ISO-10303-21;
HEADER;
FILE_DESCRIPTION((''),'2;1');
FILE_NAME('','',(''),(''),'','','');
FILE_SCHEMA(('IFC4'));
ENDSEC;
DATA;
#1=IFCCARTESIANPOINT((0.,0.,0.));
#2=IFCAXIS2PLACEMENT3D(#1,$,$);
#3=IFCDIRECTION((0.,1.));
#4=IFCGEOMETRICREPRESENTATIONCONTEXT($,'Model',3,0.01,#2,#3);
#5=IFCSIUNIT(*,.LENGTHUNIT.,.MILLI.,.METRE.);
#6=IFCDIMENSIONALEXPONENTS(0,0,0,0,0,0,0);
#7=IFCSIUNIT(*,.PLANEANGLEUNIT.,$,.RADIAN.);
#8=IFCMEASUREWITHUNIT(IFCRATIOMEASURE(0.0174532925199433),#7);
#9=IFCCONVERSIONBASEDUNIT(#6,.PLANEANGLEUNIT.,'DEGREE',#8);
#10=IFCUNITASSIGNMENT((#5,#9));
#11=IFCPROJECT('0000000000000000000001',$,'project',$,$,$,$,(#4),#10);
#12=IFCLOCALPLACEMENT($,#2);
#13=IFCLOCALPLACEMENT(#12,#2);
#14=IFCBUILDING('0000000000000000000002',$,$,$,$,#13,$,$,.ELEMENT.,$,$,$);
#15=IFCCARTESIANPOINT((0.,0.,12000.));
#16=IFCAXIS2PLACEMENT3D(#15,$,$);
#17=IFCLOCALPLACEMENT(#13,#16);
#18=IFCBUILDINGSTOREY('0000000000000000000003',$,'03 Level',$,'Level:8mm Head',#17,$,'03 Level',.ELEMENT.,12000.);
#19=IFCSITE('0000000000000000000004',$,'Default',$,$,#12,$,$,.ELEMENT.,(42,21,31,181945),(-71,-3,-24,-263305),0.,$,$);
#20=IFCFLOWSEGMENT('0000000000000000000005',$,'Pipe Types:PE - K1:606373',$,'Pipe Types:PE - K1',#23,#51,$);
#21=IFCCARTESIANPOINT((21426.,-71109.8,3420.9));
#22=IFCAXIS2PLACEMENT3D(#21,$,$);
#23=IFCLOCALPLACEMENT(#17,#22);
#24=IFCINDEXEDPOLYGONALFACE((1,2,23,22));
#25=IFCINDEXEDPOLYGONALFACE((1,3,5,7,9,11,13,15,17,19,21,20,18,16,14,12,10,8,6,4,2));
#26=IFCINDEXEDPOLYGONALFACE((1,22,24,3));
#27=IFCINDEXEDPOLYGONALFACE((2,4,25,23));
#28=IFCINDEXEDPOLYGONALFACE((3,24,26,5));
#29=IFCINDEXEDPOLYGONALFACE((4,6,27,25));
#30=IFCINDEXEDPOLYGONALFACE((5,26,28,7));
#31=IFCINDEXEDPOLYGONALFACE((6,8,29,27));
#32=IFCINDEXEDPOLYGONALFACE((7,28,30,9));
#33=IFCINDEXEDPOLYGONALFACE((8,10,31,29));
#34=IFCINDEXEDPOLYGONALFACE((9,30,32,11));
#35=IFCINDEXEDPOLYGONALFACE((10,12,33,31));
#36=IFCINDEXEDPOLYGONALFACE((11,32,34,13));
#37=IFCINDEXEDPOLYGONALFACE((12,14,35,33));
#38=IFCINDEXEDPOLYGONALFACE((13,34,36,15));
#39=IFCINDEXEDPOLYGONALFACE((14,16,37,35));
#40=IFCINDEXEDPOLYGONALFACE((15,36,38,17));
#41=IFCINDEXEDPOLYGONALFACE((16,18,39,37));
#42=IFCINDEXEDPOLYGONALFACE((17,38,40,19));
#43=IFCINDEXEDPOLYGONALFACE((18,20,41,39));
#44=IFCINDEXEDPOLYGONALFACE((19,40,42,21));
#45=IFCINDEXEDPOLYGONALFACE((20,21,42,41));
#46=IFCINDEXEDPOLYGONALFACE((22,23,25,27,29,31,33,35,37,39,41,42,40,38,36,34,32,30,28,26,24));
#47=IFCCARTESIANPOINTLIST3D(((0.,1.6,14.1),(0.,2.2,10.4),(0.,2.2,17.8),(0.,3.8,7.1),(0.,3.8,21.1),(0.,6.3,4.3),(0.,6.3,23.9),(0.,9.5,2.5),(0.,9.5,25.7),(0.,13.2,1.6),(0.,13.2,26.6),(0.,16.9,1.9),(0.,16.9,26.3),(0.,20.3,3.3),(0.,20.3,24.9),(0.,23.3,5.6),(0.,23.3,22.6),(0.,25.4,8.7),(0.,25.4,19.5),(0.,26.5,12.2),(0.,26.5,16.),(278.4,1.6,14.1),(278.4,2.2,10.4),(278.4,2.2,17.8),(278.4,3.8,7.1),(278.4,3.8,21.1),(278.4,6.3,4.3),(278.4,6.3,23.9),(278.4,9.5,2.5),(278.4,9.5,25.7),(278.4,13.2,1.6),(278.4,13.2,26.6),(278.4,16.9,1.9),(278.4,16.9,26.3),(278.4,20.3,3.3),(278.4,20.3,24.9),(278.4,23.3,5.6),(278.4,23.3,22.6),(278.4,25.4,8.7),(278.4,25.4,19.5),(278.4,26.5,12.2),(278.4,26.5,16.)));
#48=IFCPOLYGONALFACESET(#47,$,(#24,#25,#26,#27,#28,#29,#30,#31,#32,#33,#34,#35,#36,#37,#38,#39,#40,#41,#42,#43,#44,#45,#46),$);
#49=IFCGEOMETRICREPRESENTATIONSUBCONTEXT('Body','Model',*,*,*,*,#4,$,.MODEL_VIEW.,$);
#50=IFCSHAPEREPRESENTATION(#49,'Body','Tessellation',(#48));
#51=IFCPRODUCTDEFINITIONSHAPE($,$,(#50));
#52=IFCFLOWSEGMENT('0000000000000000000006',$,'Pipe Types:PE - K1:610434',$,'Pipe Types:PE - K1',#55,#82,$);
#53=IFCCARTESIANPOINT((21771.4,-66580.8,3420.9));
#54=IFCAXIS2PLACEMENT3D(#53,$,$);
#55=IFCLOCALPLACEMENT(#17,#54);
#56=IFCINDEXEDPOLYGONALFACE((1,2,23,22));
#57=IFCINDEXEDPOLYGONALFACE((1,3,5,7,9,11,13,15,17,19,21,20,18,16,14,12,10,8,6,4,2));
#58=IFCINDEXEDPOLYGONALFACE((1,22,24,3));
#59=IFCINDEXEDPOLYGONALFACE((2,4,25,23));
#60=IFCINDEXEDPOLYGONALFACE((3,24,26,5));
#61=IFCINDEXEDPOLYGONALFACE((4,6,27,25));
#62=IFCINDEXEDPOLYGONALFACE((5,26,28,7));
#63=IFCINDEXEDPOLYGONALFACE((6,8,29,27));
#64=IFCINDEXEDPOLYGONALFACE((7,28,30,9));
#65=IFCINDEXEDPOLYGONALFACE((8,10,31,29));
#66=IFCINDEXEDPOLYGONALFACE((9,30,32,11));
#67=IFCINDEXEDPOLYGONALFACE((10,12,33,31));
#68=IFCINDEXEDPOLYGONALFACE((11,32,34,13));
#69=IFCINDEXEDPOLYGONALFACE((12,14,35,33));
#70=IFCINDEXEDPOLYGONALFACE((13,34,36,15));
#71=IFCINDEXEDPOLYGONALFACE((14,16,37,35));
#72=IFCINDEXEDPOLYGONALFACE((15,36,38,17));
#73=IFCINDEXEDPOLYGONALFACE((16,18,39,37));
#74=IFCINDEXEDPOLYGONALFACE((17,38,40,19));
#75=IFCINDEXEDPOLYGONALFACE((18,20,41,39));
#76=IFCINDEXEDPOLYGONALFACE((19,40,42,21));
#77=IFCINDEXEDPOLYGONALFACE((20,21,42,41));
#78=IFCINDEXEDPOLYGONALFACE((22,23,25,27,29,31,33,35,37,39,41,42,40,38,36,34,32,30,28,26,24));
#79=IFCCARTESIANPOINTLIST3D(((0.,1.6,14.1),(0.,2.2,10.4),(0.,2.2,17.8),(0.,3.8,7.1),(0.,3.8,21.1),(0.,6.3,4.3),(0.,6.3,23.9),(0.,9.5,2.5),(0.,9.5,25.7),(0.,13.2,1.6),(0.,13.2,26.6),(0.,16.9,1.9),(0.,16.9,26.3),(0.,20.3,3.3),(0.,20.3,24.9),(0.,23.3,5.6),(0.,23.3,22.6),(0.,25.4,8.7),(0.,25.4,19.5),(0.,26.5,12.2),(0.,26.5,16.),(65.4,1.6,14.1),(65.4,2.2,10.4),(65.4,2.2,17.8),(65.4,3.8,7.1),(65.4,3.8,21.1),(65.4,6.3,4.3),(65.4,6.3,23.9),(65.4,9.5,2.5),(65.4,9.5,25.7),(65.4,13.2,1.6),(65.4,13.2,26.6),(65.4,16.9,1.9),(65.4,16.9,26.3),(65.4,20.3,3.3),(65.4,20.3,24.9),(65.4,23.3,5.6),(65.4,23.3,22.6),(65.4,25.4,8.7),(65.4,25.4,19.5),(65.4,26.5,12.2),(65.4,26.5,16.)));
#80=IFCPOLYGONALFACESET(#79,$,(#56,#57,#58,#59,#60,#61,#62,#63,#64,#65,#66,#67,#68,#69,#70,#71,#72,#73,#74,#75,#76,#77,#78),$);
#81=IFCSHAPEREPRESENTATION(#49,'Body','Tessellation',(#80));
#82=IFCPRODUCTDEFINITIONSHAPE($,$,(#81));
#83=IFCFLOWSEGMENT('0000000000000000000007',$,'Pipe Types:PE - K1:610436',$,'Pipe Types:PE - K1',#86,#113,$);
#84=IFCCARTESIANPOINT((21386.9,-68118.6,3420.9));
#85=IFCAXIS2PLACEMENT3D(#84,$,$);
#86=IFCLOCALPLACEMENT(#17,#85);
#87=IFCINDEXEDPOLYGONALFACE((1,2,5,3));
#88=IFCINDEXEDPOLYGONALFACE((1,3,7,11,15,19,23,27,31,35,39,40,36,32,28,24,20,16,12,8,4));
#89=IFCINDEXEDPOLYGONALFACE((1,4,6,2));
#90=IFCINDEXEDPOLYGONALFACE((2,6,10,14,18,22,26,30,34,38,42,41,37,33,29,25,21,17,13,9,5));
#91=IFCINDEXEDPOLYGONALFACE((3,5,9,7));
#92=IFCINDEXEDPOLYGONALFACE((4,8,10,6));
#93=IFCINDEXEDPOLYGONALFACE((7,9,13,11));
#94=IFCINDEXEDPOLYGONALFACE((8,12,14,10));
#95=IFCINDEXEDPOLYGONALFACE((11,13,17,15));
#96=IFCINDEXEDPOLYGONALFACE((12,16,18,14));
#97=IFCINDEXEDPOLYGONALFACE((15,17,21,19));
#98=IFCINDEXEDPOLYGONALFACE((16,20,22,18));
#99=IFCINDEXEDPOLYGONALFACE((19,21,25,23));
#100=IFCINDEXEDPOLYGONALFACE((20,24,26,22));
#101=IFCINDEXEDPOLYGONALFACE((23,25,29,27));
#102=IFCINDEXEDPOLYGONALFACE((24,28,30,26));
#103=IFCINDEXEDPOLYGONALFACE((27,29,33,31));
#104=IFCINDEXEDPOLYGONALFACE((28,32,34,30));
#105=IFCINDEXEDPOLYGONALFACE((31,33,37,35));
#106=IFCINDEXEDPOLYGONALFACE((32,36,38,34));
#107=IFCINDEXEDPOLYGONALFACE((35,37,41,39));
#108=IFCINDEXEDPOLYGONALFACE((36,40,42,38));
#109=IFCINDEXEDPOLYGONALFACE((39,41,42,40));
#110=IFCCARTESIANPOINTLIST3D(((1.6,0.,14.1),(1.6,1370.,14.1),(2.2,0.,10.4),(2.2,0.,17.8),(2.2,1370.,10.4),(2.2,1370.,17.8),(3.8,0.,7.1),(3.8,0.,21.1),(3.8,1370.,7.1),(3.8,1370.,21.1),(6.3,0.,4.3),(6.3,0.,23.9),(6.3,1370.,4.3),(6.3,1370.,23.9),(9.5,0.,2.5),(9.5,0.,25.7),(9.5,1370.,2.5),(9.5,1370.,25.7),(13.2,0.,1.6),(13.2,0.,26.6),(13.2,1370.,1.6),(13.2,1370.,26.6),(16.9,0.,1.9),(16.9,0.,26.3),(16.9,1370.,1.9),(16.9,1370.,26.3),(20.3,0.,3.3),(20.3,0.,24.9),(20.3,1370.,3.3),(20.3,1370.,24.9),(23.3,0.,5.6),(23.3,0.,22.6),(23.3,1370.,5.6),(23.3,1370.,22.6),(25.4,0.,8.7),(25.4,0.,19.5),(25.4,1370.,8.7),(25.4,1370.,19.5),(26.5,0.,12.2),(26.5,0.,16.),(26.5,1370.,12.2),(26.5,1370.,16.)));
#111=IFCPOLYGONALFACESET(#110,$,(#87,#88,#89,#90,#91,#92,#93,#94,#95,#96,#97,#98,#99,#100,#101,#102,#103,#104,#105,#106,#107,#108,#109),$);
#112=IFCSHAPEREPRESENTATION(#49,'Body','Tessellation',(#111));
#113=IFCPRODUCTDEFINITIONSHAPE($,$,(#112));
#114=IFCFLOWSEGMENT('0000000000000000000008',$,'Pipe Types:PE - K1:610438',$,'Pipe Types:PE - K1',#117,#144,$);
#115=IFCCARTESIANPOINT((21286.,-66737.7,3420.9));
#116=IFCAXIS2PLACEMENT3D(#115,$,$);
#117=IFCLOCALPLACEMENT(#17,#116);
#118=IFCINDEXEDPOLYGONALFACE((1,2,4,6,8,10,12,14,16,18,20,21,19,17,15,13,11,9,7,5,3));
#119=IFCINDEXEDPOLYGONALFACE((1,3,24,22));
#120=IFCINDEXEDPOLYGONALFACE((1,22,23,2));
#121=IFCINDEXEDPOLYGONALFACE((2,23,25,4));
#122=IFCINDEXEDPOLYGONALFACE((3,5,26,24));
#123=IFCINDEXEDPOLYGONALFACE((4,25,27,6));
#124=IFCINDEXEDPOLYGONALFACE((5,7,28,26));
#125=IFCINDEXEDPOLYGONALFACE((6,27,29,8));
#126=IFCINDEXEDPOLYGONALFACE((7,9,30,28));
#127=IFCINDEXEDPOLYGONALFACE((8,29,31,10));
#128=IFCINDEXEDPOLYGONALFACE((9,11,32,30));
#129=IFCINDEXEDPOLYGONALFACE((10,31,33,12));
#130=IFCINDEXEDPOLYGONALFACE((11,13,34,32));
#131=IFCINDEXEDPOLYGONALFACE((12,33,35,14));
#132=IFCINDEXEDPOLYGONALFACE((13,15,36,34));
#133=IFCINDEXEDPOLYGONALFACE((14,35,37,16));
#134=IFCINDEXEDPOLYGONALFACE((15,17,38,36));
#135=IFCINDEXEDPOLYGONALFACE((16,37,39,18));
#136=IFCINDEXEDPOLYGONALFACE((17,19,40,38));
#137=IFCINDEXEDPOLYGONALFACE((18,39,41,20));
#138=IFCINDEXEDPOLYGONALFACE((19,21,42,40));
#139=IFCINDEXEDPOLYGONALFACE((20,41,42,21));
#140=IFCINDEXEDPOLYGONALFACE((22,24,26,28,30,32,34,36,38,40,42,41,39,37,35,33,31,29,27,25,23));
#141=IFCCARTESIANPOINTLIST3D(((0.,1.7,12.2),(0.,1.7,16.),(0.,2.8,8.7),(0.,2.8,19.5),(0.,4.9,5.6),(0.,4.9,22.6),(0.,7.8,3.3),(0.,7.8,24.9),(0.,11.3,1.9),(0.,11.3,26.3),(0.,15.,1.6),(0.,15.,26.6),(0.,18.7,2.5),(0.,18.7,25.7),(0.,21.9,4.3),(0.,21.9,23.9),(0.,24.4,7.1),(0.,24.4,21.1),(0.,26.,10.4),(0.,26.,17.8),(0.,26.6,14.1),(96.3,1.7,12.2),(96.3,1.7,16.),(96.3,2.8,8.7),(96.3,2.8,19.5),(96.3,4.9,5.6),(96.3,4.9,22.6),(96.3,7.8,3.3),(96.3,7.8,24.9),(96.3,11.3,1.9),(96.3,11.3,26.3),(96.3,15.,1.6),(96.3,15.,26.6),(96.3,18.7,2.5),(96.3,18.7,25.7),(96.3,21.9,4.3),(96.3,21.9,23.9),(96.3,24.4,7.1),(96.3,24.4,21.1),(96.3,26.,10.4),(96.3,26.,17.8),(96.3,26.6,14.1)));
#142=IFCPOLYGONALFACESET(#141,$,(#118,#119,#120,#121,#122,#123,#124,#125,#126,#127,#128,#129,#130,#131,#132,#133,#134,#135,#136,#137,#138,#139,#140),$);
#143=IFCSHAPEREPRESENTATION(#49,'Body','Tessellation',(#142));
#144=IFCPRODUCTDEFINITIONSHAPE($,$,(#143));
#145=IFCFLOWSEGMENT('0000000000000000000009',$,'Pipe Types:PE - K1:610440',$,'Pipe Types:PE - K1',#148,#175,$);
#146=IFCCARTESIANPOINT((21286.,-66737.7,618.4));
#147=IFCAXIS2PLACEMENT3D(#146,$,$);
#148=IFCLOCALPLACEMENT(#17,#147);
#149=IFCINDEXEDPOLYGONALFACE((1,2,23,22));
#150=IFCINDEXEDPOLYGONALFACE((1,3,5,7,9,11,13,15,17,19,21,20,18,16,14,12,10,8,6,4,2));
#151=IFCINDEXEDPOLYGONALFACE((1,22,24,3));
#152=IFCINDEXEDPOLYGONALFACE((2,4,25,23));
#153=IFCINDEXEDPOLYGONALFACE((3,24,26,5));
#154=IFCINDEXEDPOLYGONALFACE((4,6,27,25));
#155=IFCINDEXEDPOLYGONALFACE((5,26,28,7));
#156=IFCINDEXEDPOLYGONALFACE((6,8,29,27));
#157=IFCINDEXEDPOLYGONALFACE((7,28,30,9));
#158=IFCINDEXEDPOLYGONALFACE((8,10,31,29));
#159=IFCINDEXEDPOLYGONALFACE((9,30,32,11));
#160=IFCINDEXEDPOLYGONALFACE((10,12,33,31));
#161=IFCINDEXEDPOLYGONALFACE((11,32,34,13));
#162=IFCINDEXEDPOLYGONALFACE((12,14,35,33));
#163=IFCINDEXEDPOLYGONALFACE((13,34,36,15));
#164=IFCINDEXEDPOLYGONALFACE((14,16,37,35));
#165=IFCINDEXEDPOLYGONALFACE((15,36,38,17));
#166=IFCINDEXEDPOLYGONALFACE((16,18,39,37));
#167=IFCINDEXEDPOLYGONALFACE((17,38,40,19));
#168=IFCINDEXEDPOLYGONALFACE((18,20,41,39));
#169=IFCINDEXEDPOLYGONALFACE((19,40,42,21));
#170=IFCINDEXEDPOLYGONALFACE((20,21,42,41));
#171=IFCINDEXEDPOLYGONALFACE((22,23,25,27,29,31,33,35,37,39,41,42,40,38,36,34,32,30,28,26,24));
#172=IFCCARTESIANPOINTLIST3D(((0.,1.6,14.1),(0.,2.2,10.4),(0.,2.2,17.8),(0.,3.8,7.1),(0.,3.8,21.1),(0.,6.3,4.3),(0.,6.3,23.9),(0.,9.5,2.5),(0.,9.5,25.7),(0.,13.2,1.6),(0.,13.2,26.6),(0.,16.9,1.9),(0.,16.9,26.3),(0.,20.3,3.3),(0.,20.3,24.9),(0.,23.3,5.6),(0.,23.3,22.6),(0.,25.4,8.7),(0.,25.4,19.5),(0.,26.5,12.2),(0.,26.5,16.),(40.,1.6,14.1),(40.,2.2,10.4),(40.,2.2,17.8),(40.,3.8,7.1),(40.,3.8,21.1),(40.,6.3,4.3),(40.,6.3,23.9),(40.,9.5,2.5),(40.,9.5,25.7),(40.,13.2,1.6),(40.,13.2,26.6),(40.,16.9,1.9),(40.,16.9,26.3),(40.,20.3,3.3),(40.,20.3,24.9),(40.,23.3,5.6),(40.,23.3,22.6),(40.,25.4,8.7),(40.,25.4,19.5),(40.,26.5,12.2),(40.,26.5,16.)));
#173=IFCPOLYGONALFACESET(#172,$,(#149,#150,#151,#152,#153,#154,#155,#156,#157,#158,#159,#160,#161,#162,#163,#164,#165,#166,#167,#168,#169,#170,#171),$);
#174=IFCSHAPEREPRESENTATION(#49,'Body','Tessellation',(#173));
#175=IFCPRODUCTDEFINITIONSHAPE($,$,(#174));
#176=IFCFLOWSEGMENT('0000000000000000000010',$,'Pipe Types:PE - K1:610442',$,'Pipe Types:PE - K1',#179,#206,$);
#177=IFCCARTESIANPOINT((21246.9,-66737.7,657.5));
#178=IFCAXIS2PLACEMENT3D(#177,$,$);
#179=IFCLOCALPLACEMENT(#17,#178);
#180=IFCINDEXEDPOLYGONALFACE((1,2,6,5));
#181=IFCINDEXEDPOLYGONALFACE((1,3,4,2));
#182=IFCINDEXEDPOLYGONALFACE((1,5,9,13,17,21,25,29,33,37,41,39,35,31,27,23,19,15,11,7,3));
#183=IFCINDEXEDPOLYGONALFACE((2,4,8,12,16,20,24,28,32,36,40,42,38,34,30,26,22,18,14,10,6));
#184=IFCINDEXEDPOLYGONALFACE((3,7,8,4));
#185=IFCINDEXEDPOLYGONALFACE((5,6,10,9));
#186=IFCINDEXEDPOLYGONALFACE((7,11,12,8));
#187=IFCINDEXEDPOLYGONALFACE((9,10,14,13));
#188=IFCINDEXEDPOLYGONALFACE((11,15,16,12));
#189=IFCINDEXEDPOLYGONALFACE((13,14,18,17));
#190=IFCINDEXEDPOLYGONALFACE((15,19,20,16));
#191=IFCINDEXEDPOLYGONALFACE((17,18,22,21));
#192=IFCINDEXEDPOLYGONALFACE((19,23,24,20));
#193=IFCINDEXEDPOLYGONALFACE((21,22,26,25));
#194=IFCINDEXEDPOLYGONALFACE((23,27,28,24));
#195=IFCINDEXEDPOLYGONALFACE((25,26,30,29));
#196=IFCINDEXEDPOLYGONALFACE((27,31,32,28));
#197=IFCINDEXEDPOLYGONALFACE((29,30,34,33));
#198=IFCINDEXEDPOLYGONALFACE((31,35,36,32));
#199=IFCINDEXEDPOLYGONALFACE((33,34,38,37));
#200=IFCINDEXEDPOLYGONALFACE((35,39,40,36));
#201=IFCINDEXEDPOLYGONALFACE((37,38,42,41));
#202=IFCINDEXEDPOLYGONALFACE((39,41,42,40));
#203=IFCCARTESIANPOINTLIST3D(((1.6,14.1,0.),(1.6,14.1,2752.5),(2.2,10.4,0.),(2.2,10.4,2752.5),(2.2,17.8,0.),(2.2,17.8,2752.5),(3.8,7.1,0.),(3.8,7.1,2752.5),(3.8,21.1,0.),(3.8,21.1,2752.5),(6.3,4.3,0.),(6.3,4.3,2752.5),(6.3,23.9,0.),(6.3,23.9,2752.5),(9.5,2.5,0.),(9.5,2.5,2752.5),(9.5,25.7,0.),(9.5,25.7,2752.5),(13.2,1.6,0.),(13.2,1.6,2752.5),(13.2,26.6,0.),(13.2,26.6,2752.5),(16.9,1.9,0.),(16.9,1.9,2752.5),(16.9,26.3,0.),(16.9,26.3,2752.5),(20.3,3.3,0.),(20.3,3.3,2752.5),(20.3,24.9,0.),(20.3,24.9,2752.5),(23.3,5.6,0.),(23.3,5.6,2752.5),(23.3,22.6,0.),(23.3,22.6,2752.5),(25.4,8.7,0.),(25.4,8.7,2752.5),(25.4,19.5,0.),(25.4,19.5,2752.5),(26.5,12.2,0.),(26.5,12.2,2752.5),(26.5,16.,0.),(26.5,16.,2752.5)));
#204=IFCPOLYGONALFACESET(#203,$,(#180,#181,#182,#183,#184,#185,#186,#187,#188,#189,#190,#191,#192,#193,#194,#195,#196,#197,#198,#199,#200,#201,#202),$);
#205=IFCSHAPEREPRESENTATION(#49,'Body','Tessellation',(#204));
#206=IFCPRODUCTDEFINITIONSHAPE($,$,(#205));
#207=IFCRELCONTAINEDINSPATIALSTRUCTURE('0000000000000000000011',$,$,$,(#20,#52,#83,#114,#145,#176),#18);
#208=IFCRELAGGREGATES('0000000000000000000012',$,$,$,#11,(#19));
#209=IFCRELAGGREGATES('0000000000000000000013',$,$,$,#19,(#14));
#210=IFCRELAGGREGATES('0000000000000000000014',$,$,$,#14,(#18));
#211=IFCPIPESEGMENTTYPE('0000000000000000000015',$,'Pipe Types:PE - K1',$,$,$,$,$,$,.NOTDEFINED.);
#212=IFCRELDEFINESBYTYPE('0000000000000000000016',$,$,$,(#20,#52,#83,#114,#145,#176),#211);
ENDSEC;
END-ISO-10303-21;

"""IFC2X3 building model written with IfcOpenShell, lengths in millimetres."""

from ifc_helpers import new_model, entity, si_unit, converted_unit, direction, frame, frame_2d, origin, origin_2d_with_axis, place, context, subcontext, project, spatial, circle, extrude, type_object, element, save


model = new_model("IFC2X3")

# Units and contexts
model_context = context("Model", 3, precision=0.01, world=origin(), true_north=direction((0.0, 1.0)))
body_context = subcontext(model_context, "Body", "Model", "MODEL_VIEW")
ifc_project = project(units=[si_unit("LENGTHUNIT", "METRE", prefix="MILLI"), converted_unit("PLANEANGLEUNIT", "DEGREE", entity("IfcRatioMeasure", 0.0174532925199433), si_unit("PLANEANGLEUNIT", "RADIAN"), dimensions=[0, 0, 0, 0, 0, 0, 0])], contexts=[model_context])

# Site, building, storey
site_placement = place(None, origin())
site = spatial("IfcSite", under=ifc_project, at=site_placement, Name="Default", CompositionType="ELEMENT", RefLatitude=(42, 21, 31, 181945), RefLongitude=(-71, -3, -24, -263305), RefElevation=0.0)
building_placement = place(site_placement, origin())
building = spatial("IfcBuilding", under=site, at=building_placement, CompositionType="ELEMENT")
storey_placement = place(building_placement, frame((0.0, 0.0, 12000.0)))
storey = spatial("IfcBuildingStorey", under=building, at=storey_placement, Name="03 Level", ObjectType="Level:8mm Head", LongName="03 Level", CompositionType="ELEMENT", Elevation=12000.0)

# Flow segments
pipe_segment_type = type_object("IfcPipeSegmentType", Name="Pipe Types:PE - K1", PredefinedType="NOTDEFINED")
flow_segment_1_placement = place(storey_placement, frame((21426.0, -71109.8, 3420.9)))
element("IfcFlowSegment", 1, at=flow_segment_1_placement, inside=storey, type_object=pipe_segment_type, Name="Pipe Types:PE - K1:606373", ObjectType="Pipe Types:PE - K1", context=body_context, shape_type="SweptSolid", body=[
    extrude(circle(Radius=12.5, at=frame_2d((0.0, 0.0), x_axis=(1.0, 0.0))), frame((0.0, 14.1, 14.1), z_axis=(1.0, 0.0, 0.0), x_axis=(0.0, -1.0, 0.0)), (0.0, 0.0, 1.0), 278.4),
])
flow_segment_2_placement = place(storey_placement, frame((21771.4, -66580.8, 3420.9)))
element("IfcFlowSegment", 2, at=flow_segment_2_placement, inside=storey, type_object=pipe_segment_type, Name="Pipe Types:PE - K1:610434", ObjectType="Pipe Types:PE - K1", context=body_context, shape_type="SweptSolid", body=[
    extrude(circle(Radius=12.5, at=origin_2d_with_axis()), frame((0.0, 14.1, 14.1), z_axis=(1.0, 0.0, 0.0), x_axis=(0.0, -1.0, 0.0)), (0.0, 0.0, 1.0), 65.4),
])
flow_segment_3_placement = place(storey_placement, frame((21386.9, -68118.6, 3420.9)))
element("IfcFlowSegment", 3, at=flow_segment_3_placement, inside=storey, type_object=pipe_segment_type, Name="Pipe Types:PE - K1:610436", ObjectType="Pipe Types:PE - K1", context=body_context, shape_type="SweptSolid", body=[
    extrude(circle(Radius=12.5, at=frame_2d((0.0, 0.0), x_axis=(1.0, 0.0))), frame((14.1, 0.0, 14.1), z_axis=(0.0, 1.0, 0.0), x_axis=(-1.0, 0.0, 0.0)), (0.0, 0.0, 1.0), 1370.0),
])
flow_segment_4_placement = place(storey_placement, frame((21286.0, -66737.7, 3420.9)))
element("IfcFlowSegment", 4, at=flow_segment_4_placement, inside=storey, type_object=pipe_segment_type, Name="Pipe Types:PE - K1:610438", ObjectType="Pipe Types:PE - K1", context=body_context, shape_type="SweptSolid", body=[
    extrude(circle(Radius=12.5, at=frame_2d((0.0, 0.0), x_axis=(1.0, 0.0))), frame((0.0, 14.1, 14.1), z_axis=(1.0, 0.0, 0.0), x_axis=(0.0, 1.0, 0.0)), (0.0, 0.0, 1.0), 96.3),
])
flow_segment_5_placement = place(storey_placement, frame((21286.0, -66737.7, 618.4)))
element("IfcFlowSegment", 5, at=flow_segment_5_placement, inside=storey, type_object=pipe_segment_type, Name="Pipe Types:PE - K1:610440", ObjectType="Pipe Types:PE - K1", context=body_context, shape_type="SweptSolid", body=[
    extrude(circle(Radius=12.5, at=origin_2d_with_axis()), frame((0.0, 14.1, 14.1), z_axis=(1.0, 0.0, 0.0), x_axis=(0.0, -1.0, 0.0)), (0.0, 0.0, 1.0), 40.0),
])
flow_segment_6_placement = place(storey_placement, frame((21246.9, -66737.7, 657.5)))
element("IfcFlowSegment", 6, at=flow_segment_6_placement, inside=storey, type_object=pipe_segment_type, Name="Pipe Types:PE - K1:610442", ObjectType="Pipe Types:PE - K1", context=body_context, shape_type="SweptSolid", body=[
    extrude(circle(Radius=12.5, at=frame_2d((0.0, 0.0), x_axis=(1.0, 0.0))), frame((14.1, 14.1, 0.0), z_axis=(0.0, 0.0, 1.0), x_axis=(-1.0, 0.0, 0.0)), (0.0, 0.0, 1.0), 2752.5),
])

save(model, "model.ifc")
